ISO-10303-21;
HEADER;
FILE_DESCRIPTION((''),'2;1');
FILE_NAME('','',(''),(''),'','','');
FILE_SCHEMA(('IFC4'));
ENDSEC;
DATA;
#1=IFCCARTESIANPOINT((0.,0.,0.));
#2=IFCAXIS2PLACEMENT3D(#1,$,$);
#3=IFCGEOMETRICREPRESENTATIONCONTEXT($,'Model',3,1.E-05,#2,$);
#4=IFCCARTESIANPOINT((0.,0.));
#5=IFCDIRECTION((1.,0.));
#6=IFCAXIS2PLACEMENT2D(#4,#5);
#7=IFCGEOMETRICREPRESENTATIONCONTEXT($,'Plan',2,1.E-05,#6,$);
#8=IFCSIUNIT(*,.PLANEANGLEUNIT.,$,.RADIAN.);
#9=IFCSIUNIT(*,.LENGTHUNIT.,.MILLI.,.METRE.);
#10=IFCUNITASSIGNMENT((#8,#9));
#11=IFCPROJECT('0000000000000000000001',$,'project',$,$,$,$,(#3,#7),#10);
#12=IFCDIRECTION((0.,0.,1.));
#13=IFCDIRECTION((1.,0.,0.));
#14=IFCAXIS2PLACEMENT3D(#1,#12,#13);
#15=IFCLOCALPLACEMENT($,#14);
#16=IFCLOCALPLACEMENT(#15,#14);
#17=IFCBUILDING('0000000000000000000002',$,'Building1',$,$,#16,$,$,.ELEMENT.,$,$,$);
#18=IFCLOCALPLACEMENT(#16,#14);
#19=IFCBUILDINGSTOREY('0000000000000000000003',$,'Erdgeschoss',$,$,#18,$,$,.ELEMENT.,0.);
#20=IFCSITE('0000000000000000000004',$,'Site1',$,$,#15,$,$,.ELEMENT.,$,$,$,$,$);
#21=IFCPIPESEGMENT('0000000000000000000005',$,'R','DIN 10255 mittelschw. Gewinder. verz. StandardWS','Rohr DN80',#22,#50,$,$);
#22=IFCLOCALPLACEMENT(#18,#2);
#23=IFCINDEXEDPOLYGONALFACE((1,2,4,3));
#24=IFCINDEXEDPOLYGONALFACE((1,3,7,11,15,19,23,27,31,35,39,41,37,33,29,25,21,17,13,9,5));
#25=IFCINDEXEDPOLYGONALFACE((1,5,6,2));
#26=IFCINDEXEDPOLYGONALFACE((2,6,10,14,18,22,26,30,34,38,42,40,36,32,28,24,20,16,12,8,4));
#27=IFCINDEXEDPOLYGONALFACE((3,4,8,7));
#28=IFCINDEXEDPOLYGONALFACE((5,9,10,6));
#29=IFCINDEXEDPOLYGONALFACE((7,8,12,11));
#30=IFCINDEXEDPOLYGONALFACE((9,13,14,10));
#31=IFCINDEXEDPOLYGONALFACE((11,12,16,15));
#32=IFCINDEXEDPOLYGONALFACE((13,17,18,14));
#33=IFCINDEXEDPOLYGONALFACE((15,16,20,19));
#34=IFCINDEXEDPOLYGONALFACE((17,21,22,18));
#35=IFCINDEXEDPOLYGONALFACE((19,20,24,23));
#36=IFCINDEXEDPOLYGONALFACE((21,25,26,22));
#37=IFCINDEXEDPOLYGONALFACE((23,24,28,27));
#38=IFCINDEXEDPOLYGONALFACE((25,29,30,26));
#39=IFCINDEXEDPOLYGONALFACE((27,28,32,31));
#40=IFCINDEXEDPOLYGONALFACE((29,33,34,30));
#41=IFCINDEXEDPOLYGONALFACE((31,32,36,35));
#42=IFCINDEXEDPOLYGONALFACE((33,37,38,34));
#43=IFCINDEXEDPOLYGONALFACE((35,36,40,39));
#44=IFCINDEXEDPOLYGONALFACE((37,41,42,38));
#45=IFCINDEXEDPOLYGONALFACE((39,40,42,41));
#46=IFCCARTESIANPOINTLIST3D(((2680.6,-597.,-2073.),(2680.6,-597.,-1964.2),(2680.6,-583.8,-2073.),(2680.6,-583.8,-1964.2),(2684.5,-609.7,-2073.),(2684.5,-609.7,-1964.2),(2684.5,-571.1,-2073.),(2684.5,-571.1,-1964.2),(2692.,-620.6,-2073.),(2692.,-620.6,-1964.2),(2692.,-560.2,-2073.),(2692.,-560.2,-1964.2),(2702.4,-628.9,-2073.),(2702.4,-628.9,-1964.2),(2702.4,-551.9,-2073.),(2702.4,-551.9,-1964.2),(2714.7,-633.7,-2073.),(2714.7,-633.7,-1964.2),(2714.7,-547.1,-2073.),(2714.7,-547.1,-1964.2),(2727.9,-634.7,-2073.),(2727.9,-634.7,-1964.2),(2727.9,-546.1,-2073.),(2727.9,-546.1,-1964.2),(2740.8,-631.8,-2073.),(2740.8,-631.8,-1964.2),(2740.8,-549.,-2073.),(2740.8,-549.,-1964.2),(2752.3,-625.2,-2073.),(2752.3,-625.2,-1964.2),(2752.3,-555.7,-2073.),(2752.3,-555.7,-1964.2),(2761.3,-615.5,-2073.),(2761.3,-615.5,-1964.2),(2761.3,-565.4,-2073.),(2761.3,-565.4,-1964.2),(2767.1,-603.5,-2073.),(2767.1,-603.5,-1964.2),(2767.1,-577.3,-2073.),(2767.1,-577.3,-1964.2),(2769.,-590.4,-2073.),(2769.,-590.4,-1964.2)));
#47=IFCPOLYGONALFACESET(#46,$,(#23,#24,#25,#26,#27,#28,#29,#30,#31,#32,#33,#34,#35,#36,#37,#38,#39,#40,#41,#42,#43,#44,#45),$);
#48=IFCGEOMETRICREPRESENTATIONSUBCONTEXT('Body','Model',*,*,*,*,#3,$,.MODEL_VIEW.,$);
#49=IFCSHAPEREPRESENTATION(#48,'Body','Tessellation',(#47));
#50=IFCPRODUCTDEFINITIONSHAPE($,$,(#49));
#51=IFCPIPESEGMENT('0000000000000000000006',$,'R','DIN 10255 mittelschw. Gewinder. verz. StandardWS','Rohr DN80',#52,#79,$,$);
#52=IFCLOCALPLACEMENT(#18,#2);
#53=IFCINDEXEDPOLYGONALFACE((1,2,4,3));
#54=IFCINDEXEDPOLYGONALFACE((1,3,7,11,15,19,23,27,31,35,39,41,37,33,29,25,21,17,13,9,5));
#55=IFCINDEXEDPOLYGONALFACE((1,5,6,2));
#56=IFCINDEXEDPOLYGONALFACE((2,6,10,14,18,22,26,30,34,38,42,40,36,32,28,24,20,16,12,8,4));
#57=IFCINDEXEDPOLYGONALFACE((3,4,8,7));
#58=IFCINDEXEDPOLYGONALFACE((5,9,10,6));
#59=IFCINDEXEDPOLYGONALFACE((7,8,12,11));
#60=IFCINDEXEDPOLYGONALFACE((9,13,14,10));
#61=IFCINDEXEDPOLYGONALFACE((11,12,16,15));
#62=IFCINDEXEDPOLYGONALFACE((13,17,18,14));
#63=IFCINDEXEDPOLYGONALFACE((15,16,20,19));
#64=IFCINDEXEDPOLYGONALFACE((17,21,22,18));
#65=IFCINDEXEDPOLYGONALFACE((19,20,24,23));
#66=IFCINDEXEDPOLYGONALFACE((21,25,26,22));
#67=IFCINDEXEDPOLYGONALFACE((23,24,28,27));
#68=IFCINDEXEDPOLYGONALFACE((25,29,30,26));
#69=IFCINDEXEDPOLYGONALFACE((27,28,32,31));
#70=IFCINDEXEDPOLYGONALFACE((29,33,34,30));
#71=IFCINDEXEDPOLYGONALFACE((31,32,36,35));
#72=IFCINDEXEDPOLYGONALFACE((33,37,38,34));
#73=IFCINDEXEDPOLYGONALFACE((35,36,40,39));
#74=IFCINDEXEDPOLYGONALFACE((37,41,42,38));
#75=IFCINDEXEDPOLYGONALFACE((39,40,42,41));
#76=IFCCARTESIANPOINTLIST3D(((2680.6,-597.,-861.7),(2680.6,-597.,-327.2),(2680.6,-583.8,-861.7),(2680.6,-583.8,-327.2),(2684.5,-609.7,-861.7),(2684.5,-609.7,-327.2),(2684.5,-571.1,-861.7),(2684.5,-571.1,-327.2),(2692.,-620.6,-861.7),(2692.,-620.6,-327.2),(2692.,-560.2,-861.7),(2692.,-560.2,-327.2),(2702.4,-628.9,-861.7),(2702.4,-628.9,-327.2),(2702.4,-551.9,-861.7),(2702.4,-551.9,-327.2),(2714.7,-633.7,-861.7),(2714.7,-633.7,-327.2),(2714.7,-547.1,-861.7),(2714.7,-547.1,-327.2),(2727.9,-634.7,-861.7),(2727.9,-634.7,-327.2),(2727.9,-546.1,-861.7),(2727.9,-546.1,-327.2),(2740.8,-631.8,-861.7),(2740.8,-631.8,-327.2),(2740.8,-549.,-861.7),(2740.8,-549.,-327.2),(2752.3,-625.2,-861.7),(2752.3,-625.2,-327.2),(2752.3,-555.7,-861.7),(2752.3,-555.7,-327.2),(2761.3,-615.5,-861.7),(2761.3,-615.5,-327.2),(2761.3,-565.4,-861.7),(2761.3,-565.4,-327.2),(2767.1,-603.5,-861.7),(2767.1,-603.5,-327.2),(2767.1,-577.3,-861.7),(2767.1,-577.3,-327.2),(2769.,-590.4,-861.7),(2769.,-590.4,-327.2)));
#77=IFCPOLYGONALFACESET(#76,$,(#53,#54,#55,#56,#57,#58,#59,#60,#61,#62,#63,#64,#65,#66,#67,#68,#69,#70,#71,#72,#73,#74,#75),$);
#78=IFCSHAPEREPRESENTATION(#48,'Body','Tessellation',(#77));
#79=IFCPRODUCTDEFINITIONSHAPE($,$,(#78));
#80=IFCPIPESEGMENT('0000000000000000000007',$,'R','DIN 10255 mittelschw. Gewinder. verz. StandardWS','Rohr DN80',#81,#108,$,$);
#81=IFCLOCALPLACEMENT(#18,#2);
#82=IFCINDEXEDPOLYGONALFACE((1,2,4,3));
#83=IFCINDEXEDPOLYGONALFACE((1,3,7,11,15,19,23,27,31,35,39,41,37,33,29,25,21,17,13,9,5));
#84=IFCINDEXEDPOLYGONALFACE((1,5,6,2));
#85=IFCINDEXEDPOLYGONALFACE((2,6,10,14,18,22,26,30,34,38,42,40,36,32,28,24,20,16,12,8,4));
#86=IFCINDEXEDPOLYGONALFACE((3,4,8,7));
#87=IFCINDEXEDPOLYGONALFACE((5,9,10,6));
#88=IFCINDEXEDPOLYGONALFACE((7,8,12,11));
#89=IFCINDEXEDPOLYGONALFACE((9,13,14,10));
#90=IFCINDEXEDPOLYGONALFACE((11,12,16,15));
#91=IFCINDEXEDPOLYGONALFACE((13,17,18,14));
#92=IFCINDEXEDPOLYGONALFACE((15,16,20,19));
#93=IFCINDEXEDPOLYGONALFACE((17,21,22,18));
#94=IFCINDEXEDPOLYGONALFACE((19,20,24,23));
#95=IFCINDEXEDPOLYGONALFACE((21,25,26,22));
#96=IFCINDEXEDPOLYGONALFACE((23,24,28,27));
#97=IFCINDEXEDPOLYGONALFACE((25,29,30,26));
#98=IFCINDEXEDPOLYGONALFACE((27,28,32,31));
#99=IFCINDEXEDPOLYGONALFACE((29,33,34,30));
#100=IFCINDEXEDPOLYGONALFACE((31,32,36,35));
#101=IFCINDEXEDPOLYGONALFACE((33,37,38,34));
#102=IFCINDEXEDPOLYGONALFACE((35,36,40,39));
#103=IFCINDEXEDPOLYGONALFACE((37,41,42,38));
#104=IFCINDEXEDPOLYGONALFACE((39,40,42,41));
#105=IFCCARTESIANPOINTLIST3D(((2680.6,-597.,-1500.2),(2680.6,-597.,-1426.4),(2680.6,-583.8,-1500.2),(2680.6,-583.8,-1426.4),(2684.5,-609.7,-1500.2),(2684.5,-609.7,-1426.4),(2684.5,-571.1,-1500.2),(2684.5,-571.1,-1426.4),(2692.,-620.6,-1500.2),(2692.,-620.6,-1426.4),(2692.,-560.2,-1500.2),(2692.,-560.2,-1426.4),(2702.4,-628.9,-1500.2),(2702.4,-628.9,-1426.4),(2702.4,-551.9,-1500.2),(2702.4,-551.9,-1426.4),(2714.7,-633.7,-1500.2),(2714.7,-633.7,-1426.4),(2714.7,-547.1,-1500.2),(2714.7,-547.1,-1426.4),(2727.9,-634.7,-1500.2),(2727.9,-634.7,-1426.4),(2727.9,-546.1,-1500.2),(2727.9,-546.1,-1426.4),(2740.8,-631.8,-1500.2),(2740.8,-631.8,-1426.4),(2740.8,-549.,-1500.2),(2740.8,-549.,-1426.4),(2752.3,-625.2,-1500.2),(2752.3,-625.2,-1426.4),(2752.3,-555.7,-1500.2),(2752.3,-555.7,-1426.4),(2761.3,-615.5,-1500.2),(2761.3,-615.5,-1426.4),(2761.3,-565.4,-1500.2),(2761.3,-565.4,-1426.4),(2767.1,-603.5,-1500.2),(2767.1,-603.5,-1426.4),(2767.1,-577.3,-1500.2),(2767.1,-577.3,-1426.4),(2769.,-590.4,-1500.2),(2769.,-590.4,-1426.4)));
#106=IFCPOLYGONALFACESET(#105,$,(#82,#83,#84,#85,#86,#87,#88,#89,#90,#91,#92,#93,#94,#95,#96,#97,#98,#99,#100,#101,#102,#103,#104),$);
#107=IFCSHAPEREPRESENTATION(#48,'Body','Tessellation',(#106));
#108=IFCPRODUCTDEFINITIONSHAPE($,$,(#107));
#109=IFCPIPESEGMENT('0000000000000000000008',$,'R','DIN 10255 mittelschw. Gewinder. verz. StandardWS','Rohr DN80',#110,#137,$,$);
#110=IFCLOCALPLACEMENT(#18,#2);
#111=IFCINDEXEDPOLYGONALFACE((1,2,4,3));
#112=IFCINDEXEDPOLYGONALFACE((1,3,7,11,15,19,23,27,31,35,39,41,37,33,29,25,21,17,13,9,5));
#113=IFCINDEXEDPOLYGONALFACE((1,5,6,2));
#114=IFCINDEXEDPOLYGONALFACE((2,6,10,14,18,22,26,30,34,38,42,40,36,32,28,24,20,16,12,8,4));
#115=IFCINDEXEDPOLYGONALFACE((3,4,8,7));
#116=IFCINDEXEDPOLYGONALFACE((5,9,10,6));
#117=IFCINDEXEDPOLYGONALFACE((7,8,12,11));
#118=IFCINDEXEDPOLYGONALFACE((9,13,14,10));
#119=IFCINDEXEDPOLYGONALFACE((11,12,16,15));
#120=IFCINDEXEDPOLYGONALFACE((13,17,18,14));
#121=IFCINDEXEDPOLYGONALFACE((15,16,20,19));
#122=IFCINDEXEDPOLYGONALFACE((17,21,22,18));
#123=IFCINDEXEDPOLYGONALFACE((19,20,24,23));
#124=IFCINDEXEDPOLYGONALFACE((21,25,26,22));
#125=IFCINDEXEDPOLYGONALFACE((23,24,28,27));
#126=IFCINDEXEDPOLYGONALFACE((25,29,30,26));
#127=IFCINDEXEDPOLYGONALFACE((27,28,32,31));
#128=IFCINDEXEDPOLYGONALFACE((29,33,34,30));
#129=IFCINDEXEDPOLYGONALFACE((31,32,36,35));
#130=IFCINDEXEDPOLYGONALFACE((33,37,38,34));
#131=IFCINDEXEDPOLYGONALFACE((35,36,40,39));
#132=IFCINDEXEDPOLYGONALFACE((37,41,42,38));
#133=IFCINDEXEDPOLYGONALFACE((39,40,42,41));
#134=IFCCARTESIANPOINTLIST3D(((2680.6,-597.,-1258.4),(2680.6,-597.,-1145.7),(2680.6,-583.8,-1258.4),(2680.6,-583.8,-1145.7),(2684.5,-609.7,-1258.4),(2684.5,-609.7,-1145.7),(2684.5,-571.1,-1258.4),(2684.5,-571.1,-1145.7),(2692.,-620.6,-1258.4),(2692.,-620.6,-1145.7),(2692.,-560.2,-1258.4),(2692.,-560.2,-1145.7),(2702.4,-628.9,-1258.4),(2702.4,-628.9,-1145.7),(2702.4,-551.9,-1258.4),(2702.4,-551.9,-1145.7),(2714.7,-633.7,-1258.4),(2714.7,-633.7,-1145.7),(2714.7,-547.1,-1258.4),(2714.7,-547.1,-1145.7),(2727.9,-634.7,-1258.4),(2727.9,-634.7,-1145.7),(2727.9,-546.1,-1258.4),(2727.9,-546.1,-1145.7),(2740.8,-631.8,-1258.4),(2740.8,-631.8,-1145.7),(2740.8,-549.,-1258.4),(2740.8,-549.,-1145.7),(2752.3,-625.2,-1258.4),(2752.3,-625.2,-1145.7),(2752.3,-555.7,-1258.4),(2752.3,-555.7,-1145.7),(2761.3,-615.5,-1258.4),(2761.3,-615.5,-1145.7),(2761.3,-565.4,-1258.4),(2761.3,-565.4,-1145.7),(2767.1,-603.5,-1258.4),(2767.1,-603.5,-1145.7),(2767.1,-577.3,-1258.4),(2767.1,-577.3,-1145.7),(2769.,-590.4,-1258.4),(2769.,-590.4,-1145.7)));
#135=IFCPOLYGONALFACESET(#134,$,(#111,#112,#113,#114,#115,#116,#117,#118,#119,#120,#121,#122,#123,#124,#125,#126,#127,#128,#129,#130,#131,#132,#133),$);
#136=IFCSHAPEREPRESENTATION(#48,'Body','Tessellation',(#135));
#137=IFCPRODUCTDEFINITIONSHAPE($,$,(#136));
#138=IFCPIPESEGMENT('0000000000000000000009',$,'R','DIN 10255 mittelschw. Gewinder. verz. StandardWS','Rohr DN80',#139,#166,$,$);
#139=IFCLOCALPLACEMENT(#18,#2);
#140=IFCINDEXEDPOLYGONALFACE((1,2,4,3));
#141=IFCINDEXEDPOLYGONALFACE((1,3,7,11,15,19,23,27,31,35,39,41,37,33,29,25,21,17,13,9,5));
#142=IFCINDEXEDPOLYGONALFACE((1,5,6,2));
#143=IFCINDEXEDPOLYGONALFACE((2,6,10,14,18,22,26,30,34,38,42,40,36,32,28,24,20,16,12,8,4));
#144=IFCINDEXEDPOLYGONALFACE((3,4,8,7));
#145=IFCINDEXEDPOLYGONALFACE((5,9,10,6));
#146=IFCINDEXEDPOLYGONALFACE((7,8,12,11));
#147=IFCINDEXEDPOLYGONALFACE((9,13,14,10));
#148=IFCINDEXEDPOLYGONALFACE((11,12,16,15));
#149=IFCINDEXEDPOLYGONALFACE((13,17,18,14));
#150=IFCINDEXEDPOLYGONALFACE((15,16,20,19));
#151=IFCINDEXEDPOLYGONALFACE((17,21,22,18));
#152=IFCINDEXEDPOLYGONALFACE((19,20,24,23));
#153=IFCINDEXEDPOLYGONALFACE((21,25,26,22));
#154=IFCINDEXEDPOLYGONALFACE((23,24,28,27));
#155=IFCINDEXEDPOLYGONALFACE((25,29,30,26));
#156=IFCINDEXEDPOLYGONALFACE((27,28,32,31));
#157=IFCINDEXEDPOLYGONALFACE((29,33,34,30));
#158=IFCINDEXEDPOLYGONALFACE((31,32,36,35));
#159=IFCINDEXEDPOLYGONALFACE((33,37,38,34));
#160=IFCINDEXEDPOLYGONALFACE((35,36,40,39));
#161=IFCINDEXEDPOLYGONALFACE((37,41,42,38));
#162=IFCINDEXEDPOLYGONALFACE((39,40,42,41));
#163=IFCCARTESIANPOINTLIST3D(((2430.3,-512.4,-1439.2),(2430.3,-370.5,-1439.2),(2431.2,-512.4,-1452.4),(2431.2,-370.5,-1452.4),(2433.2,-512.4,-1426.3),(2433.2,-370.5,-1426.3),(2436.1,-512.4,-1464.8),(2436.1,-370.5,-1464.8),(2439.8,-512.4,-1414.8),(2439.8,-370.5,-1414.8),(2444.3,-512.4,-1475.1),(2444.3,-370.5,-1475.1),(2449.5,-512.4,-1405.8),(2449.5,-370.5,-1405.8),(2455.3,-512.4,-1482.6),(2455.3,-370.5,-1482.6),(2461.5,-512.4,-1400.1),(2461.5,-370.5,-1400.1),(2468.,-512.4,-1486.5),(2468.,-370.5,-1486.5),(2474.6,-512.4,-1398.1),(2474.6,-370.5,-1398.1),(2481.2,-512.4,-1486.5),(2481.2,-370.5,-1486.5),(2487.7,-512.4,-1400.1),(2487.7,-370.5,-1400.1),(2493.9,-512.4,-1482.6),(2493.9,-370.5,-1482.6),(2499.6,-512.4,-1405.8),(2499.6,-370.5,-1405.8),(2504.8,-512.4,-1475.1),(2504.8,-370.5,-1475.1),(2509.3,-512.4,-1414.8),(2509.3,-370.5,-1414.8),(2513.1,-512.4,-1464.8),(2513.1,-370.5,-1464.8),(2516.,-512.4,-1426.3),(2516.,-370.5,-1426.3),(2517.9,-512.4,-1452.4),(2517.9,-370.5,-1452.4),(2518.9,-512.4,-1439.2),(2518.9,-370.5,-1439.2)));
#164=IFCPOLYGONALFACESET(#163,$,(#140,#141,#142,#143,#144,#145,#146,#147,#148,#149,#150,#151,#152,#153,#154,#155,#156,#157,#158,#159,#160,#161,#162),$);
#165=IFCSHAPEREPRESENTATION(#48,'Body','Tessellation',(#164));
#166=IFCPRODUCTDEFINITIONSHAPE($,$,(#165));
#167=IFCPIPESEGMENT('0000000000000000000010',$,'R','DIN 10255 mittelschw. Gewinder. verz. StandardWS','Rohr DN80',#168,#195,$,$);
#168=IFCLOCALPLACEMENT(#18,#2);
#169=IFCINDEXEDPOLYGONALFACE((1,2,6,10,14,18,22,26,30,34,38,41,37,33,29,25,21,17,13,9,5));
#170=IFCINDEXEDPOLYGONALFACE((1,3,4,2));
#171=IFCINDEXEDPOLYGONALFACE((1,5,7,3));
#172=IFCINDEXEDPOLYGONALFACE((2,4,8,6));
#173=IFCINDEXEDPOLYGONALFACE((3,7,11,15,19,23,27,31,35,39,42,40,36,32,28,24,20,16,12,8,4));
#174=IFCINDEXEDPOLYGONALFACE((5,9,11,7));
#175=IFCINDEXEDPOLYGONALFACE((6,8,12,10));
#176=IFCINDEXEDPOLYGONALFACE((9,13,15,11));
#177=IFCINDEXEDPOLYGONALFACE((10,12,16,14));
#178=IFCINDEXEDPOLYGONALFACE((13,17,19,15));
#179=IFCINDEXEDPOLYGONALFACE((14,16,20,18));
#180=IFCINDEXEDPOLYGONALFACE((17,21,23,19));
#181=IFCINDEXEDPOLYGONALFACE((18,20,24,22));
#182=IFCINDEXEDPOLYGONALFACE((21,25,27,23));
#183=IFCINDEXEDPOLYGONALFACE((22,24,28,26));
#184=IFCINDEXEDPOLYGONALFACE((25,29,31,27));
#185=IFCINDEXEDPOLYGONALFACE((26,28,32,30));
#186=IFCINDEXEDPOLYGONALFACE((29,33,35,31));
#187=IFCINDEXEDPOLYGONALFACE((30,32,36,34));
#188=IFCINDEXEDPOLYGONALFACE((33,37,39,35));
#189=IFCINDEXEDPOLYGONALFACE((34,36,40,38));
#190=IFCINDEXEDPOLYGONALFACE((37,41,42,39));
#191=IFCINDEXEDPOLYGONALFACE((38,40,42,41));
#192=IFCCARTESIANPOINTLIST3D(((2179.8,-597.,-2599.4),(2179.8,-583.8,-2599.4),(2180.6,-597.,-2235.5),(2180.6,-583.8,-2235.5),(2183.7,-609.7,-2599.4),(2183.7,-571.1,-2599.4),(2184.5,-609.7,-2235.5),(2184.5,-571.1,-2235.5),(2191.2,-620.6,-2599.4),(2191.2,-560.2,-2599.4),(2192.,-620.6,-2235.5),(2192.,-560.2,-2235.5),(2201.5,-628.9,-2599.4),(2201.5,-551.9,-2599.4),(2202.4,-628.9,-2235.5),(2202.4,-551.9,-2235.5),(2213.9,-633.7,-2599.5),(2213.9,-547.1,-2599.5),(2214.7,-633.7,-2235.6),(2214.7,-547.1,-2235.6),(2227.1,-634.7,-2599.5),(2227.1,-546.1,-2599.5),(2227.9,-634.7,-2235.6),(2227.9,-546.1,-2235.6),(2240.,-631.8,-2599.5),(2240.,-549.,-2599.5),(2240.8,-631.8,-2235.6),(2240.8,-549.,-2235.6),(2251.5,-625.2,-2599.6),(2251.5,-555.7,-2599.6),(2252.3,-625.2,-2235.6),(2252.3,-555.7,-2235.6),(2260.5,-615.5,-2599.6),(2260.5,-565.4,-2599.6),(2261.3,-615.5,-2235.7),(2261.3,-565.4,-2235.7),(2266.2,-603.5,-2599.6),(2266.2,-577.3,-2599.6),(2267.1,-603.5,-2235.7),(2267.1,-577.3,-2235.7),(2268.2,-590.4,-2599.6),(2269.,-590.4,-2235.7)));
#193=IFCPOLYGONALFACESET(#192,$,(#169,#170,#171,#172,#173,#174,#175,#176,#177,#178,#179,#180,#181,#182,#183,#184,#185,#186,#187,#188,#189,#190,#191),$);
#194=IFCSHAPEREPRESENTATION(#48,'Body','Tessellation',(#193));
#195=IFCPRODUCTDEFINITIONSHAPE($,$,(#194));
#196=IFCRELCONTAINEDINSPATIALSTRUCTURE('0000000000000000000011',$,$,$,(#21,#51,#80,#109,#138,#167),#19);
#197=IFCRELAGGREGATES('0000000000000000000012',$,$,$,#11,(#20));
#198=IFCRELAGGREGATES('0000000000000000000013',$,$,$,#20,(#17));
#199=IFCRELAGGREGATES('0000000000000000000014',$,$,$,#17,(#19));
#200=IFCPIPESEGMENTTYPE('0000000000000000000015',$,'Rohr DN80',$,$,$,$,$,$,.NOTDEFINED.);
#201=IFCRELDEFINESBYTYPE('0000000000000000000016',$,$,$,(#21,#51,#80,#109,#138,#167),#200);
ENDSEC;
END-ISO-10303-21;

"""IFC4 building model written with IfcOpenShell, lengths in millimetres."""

from ifc_helpers import new_model, si_unit, frame, origin, origin_with_axes, origin_2d_with_axis, place, context, subcontext, project, spatial, circle, extrude, type_object, element, save


model = new_model("IFC4")

# Units and contexts
model_context = context("Model", 3, precision=1e-05, world=origin())
plan_context = context("Plan", 2, precision=1e-05, world=origin_2d_with_axis())
body_context = subcontext(model_context, "Body", "Model", "MODEL_VIEW")
ifc_project = project(units=[si_unit("PLANEANGLEUNIT", "RADIAN"), si_unit("LENGTHUNIT", "METRE", prefix="MILLI")], contexts=[model_context, plan_context])

# Site, building, storey
site_placement = place(None, origin_with_axes())
site = spatial("IfcSite", under=ifc_project, at=site_placement, Name="Site1", CompositionType="ELEMENT")
building_placement = place(site_placement, origin_with_axes())
building = spatial("IfcBuilding", under=site, at=building_placement, Name="Building1", CompositionType="ELEMENT")
storey_placement = place(building_placement, origin_with_axes())
storey = spatial("IfcBuildingStorey", under=building, at=storey_placement, Name="Erdgeschoss", CompositionType="ELEMENT", Elevation=0.0)

# Pipe segments
pipe_segment_type_1 = type_object("IfcPipeSegmentType", Name="Rohr DN80", PredefinedType="NOTDEFINED")
pipe_segment_1_placement = place(storey_placement, frame((2724.6, -590.6, -2018.6), z_axis=(0.0, 0.0, 1.0), x_axis=(1.0, 0.0, 0.0)))
element("IfcPipeSegment", 1, at=pipe_segment_1_placement, inside=storey, type_object=pipe_segment_type_1, Name="R", Description="DIN 10255 mittelschw. Gewinder. verz. StandardWS", ObjectType="Rohr DN80", context=body_context, shape_type="SolidModel", body=[
    extrude(circle(Radius=44.5, at=origin_2d_with_axis()), frame((0.0, 0.1, -54.4), z_axis=(0.0, 0.0, 1.0), x_axis=(1.0, 0.0, 0.0)), (0.0, 0.0, 1.0), 108.8),
])
pipe_segment_2_placement = place(storey_placement, frame((2724.6, -590.6, -594.5), z_axis=(0.0, 0.0, 1.0), x_axis=(1.0, 0.0, 0.0)))
element("IfcPipeSegment", 2, at=pipe_segment_2_placement, inside=storey, type_object=pipe_segment_type_1, Name="R", Description="DIN 10255 mittelschw. Gewinder. verz. StandardWS", ObjectType="Rohr DN80", context=body_context, shape_type="SolidModel", body=[
    extrude(circle(Radius=44.5, at=origin_2d_with_axis()), frame((0.0, 0.1, -267.2), z_axis=(0.0, 0.0, 1.0), x_axis=(1.0, 0.0, 0.0)), (0.0, 0.0, 1.0), 534.5),
])
pipe_segment_3_placement = place(storey_placement, frame((2724.6, -590.6, -1463.3), z_axis=(0.0, 0.0, 1.0), x_axis=(1.0, 0.0, 0.0)))
element("IfcPipeSegment", 3, at=pipe_segment_3_placement, inside=storey, type_object=pipe_segment_type_1, Name="R", Description="DIN 10255 mittelschw. Gewinder. verz. StandardWS", ObjectType="Rohr DN80", context=body_context, shape_type="SolidModel", body=[
    extrude(circle(Radius=44.5, at=origin_2d_with_axis()), frame((0.0, 0.1, -36.9), z_axis=(0.0, 0.0, 1.0), x_axis=(1.0, 0.0, 0.0)), (0.0, 0.0, 1.0), 73.8),
])
pipe_segment_4_placement = place(storey_placement, frame((2724.6, -590.6, -1202.1), z_axis=(0.0, 0.0, 1.0), x_axis=(1.0, 0.0, 0.0)))
element("IfcPipeSegment", 4, at=pipe_segment_4_placement, inside=storey, type_object=pipe_segment_type_1, Name="R", Description="DIN 10255 mittelschw. Gewinder. verz. StandardWS", ObjectType="Rohr DN80", context=body_context, shape_type="SolidModel", body=[
    extrude(circle(Radius=44.5, at=origin_2d_with_axis()), frame((0.0, 0.1, -56.3), z_axis=(0.0, 0.0, 1.0), x_axis=(1.0, 0.0, 0.0)), (0.0, 0.0, 1.0), 112.7),
])
pipe_segment_5_placement = place(storey_placement, frame((2474.4, -441.5, -1442.5), z_axis=(0.0, 0.0, 1.0), x_axis=(1.0, 0.0, 0.0)))
element("IfcPipeSegment", 5, at=pipe_segment_5_placement, inside=storey, type_object=pipe_segment_type_1, Name="R", Description="DIN 10255 mittelschw. Gewinder. verz. StandardWS", ObjectType="Rohr DN80", context=body_context, shape_type="SolidModel", body=[
    extrude(circle(Radius=44.5, at=origin_2d_with_axis()), frame((0.2, -70.9, 0.0), z_axis=(0.0, 1.0, 0.0), x_axis=(0.0, 0.0, 1.0)), (0.0, 0.0, 1.0), 141.9),
])
pipe_segment_6_placement = place(storey_placement, frame((2224.2, -590.6, -2417.5), z_axis=(0.0, 0.0, 1.0), x_axis=(1.0, 0.0, 0.0)))
element("IfcPipeSegment", 6, at=pipe_segment_6_placement, inside=storey, type_object=pipe_segment_type_1, Name="R", Description="DIN 10255 mittelschw. Gewinder. verz. StandardWS", ObjectType="Rohr DN80", context=body_context, shape_type="SolidModel", body=[
    extrude(circle(Radius=44.5, at=origin_2d_with_axis()), frame((-0.4, 0.1, -182.0), z_axis=(0.002292, 0.0, 0.999997), x_axis=(1.0, 0.0, 0.0)), (0.0, 0.0, 1.0), 363.9),
])

save(model, "model.ifc")
